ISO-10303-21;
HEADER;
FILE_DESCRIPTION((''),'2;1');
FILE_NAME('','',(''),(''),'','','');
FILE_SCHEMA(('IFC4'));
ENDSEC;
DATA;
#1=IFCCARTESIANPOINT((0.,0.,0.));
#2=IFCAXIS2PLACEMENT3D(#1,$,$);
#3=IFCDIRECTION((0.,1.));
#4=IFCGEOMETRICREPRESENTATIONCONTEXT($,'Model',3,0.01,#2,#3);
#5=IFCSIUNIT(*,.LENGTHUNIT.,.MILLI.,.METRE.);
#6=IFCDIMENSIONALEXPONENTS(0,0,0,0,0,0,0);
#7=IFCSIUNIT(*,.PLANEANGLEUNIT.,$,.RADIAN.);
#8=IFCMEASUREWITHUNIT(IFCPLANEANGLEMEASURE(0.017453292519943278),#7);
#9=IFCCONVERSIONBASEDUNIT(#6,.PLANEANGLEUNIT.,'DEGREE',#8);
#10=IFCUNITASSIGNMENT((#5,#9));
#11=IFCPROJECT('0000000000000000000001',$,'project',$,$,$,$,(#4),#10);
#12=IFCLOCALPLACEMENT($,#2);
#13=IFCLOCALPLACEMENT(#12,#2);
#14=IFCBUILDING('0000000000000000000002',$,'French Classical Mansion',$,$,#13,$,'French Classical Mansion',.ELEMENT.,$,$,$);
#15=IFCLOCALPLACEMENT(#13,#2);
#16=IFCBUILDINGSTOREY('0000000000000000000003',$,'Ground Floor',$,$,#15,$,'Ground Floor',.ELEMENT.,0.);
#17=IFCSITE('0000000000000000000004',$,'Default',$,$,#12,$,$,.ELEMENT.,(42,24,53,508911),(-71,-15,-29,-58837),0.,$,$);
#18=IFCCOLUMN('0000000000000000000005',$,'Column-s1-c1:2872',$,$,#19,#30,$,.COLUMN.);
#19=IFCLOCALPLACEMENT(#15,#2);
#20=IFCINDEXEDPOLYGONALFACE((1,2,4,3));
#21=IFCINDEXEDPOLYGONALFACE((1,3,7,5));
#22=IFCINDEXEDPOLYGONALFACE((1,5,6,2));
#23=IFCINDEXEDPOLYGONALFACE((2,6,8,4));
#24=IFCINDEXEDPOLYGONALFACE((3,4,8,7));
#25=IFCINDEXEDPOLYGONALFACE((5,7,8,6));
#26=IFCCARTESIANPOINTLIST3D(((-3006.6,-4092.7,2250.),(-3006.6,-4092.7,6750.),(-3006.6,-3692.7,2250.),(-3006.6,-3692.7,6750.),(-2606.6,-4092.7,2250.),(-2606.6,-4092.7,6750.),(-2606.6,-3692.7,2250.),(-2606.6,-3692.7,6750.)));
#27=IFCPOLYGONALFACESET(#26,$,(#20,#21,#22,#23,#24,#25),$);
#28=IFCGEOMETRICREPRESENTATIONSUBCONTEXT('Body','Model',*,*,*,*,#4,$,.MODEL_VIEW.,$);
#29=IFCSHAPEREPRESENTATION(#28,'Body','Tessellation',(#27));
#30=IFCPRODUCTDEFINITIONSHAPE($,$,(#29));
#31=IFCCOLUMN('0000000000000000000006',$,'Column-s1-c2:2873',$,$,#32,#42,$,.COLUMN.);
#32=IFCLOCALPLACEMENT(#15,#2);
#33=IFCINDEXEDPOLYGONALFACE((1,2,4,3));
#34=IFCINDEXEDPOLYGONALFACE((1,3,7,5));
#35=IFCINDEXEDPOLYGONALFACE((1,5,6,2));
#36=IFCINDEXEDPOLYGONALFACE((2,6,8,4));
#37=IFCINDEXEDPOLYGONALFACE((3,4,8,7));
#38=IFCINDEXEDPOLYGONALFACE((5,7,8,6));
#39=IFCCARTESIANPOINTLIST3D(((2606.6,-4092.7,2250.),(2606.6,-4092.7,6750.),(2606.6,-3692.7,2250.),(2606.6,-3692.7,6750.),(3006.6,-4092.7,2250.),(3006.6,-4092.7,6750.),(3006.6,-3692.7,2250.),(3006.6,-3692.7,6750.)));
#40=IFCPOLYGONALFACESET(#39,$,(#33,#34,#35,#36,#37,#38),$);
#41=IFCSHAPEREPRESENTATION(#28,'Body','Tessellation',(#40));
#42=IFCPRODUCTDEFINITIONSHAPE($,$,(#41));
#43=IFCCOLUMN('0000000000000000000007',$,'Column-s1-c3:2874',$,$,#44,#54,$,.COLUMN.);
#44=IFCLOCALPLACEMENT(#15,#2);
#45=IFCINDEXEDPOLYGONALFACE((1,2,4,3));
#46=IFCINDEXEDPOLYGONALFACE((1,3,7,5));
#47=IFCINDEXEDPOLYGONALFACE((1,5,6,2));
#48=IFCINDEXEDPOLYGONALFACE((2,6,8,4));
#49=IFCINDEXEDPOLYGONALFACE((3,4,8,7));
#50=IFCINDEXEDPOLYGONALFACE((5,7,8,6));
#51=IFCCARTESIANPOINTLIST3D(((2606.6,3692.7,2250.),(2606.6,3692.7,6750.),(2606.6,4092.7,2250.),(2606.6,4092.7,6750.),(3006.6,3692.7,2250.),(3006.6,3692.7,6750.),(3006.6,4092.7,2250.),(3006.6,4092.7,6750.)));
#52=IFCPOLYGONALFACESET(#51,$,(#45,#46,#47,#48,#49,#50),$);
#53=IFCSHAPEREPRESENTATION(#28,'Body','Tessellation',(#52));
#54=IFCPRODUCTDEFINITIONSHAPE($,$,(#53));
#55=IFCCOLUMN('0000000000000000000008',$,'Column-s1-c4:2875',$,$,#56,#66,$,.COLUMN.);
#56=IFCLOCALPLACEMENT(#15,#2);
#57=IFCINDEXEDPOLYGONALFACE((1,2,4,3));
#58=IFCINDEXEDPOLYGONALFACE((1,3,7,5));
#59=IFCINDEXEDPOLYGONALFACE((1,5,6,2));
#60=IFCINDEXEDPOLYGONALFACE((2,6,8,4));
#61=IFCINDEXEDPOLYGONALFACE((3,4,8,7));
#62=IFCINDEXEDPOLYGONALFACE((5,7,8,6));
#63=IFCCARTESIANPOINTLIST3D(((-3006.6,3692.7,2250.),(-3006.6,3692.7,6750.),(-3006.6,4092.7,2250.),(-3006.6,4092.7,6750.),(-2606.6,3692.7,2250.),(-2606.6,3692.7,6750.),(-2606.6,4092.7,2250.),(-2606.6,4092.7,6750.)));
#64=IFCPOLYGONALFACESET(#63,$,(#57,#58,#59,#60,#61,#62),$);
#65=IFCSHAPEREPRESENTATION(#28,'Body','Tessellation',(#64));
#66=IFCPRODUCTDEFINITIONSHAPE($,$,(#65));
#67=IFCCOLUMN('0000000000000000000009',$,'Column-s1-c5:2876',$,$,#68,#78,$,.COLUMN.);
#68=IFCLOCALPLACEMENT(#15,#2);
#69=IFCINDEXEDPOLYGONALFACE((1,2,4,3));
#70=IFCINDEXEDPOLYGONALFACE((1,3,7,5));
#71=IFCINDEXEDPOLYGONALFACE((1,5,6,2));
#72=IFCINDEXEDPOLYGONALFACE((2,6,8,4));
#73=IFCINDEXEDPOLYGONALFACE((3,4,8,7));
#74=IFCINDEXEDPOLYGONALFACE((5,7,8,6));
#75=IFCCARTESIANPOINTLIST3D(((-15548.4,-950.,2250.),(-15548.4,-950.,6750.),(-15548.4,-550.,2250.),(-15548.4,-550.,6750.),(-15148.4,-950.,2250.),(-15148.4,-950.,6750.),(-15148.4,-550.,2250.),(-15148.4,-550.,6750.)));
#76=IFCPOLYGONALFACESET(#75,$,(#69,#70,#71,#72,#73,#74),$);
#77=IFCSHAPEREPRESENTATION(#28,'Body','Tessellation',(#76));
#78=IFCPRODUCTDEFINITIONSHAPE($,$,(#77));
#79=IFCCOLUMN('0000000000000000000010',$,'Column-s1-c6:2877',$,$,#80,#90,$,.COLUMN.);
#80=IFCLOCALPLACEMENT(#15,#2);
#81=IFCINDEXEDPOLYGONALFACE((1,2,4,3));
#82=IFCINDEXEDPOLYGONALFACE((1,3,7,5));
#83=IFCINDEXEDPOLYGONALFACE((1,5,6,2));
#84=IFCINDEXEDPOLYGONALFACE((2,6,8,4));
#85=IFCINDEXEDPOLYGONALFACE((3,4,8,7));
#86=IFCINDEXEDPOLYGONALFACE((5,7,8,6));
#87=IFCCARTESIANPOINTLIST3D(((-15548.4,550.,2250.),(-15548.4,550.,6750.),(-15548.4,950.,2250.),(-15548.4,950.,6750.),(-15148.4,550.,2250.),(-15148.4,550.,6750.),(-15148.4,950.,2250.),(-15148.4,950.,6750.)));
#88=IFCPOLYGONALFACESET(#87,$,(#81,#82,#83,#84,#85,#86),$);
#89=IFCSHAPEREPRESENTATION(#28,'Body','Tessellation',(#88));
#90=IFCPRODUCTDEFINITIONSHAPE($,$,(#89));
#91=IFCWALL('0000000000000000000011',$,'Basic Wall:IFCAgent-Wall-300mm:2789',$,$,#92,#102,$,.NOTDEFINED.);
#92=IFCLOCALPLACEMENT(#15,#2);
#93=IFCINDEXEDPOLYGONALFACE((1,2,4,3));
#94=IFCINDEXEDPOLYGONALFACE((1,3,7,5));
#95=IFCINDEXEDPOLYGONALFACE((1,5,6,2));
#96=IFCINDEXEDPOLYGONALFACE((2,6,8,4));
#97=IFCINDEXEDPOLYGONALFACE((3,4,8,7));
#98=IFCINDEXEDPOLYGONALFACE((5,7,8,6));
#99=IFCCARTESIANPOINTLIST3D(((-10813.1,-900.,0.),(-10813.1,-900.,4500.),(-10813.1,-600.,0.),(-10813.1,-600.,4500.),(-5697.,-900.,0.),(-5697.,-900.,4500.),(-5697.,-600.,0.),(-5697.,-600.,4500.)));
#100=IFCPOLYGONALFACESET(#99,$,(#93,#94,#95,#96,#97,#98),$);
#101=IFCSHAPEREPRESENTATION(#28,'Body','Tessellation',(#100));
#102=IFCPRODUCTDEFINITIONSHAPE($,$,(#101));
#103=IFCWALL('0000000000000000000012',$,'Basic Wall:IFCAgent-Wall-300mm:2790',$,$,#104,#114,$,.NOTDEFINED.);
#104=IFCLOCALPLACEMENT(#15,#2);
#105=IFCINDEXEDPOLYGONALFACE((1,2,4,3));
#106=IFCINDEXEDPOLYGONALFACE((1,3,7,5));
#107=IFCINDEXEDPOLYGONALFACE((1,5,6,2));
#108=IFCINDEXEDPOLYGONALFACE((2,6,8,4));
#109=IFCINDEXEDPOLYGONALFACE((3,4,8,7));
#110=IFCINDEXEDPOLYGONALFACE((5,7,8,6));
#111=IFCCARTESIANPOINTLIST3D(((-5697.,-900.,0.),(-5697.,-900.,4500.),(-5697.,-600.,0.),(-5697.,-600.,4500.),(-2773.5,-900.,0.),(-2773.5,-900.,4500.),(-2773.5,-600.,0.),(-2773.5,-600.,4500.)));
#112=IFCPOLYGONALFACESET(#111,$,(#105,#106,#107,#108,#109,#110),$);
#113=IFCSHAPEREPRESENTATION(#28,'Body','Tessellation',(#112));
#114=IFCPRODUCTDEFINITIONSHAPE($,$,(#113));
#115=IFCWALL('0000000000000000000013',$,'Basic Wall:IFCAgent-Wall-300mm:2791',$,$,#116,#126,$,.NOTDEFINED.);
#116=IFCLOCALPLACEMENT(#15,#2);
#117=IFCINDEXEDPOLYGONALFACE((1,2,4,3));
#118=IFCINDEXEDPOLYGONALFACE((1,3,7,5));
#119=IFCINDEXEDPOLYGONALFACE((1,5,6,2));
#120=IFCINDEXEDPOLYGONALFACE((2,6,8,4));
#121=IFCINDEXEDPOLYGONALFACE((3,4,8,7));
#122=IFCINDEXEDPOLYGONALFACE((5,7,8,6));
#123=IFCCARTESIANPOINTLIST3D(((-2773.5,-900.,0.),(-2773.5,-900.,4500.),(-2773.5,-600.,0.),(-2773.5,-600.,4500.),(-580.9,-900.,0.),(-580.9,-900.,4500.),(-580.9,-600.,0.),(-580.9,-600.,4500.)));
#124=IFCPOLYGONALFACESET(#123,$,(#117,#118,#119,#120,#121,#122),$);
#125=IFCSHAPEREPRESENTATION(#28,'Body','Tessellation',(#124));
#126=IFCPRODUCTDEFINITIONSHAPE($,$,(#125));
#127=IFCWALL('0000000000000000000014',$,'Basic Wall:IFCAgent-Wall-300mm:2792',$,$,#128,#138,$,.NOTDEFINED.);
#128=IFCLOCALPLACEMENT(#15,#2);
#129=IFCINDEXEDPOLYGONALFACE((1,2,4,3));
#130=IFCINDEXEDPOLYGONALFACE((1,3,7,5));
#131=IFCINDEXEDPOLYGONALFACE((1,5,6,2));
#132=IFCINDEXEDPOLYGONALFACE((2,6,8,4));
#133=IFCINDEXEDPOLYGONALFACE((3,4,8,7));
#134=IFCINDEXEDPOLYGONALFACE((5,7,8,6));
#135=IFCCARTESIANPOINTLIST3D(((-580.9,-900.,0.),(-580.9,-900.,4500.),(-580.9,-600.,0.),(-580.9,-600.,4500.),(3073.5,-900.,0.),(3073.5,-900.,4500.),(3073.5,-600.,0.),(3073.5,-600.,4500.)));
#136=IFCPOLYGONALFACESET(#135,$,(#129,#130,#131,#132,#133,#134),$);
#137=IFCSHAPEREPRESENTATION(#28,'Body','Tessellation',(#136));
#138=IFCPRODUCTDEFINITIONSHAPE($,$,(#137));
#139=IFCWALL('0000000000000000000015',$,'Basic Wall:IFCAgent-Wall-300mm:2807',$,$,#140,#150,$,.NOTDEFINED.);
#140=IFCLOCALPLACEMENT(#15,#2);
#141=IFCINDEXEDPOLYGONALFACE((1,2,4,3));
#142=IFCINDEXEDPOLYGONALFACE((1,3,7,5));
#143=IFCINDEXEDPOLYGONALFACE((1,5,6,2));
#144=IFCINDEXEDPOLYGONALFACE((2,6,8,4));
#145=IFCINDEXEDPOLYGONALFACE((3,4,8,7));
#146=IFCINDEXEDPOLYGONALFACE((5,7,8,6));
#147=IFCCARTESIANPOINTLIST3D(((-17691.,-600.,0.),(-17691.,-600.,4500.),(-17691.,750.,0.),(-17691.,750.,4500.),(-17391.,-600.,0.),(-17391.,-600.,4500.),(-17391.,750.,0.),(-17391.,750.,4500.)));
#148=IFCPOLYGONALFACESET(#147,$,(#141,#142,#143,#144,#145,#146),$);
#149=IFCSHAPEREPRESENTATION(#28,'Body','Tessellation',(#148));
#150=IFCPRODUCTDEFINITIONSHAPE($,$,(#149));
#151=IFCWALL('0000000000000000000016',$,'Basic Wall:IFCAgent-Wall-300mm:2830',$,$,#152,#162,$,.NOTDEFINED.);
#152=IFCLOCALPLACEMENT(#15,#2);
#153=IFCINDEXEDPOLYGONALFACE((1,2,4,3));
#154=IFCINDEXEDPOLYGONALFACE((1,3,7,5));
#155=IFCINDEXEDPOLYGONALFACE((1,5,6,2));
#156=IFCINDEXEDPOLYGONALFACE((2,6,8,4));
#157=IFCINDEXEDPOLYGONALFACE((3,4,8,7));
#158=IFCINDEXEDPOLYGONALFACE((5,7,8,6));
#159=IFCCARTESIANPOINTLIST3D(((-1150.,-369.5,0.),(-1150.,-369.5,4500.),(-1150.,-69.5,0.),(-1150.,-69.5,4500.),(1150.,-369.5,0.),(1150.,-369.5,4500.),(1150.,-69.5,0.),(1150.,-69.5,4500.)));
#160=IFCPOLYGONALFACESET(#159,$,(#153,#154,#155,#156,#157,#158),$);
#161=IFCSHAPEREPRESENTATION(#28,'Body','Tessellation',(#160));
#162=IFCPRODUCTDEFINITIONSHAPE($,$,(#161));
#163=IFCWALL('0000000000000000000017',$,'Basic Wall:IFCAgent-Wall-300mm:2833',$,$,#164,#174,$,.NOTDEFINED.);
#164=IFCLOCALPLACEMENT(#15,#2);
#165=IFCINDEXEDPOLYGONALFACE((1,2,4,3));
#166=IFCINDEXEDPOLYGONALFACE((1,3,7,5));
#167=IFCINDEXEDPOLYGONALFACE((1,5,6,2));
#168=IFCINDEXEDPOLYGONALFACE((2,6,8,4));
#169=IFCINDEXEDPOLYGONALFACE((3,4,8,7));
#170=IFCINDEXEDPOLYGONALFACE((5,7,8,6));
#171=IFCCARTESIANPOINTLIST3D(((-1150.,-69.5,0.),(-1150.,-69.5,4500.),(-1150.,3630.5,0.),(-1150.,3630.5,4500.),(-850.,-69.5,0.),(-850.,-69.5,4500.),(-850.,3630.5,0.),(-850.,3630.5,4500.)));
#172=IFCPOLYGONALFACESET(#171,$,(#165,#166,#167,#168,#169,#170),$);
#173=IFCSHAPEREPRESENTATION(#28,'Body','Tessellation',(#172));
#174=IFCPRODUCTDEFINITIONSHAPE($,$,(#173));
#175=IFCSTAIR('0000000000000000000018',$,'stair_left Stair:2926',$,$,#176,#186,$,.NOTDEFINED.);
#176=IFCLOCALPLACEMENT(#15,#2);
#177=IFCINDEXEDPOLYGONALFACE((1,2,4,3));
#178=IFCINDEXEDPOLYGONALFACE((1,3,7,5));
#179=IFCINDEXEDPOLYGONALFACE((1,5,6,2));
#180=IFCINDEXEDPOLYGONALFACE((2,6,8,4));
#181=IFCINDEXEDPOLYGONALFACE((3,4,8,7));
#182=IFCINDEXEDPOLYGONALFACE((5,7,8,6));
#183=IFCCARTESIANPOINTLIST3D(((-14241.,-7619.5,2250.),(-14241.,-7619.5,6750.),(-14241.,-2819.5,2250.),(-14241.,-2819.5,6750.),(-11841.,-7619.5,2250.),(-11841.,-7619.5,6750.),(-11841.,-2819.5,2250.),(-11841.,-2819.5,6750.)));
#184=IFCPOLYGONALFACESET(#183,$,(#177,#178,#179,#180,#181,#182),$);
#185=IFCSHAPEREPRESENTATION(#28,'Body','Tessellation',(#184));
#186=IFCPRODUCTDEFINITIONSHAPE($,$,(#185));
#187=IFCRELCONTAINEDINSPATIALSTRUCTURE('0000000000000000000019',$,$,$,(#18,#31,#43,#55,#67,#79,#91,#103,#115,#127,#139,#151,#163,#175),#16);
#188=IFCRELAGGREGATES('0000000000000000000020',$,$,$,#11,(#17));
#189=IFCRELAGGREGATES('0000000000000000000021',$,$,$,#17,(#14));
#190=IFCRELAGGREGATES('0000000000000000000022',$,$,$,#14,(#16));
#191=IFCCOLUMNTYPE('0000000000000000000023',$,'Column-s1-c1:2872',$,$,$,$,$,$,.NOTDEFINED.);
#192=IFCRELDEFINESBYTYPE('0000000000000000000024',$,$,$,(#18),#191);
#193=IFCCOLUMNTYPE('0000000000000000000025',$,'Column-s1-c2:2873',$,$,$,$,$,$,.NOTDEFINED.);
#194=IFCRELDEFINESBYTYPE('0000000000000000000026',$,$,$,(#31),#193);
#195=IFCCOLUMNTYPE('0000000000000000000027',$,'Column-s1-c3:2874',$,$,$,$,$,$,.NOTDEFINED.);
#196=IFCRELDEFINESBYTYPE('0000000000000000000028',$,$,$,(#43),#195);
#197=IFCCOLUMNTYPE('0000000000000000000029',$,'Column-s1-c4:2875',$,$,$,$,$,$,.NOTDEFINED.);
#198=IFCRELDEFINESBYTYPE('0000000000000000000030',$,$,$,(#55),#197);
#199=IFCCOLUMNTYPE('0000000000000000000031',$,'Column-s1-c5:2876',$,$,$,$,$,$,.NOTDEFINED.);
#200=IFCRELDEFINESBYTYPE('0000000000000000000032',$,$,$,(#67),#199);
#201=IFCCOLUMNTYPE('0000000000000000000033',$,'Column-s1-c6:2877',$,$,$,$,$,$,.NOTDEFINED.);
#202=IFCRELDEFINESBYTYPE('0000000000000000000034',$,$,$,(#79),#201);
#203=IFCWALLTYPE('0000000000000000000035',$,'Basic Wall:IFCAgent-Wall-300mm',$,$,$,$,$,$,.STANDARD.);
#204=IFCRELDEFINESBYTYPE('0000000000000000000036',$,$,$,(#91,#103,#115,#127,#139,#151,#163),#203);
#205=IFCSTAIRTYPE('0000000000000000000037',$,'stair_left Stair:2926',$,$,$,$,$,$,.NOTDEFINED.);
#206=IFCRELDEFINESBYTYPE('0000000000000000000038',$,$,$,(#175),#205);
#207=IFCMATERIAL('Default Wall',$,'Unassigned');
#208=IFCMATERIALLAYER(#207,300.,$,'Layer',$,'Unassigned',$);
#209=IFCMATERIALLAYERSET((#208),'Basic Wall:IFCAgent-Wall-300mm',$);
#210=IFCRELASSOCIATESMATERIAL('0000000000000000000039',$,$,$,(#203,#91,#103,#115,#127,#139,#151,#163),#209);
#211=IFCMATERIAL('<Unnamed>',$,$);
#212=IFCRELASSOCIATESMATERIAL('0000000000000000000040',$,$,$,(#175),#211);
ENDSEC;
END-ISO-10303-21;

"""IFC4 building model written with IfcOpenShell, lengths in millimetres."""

from ifc_helpers import new_model, entity, si_unit, converted_unit, direction, frame, frame_2d, origin, origin_2d_with_axis, place, context, subcontext, project, spatial, rectangle, extrude, material, layer, layer_set, layer_usage, type_object, element, save


model = new_model("IFC4")

# Units and contexts
model_context = context("Model", 3, precision=0.01, world=origin(), true_north=direction((0.0, 1.0)))
body_context = subcontext(model_context, "Body", "Model", "MODEL_VIEW")
ifc_project = project(units=[si_unit("LENGTHUNIT", "METRE", prefix="MILLI"), converted_unit("PLANEANGLEUNIT", "DEGREE", entity("IfcPlaneAngleMeasure", 0.017453292519943278), si_unit("PLANEANGLEUNIT", "RADIAN"), dimensions=[0, 0, 0, 0, 0, 0, 0])], contexts=[model_context])

# Site, building, storey
site_placement = place(None, origin())
site = spatial("IfcSite", under=ifc_project, at=site_placement, Name="Default", CompositionType="ELEMENT", RefLatitude=(42, 24, 53, 508911), RefLongitude=(-71, -15, -29, -58837), RefElevation=0.0)
building_placement = place(site_placement, origin())
building = spatial("IfcBuilding", under=site, at=building_placement, Name="French Classical Mansion", LongName="French Classical Mansion", CompositionType="ELEMENT")
storey_placement = place(building_placement, origin())
storey = spatial("IfcBuildingStorey", under=building, at=storey_placement, Name="Ground Floor", LongName="Ground Floor", CompositionType="ELEMENT", Elevation=0.0)

# Columns
column_type_1 = type_object("IfcColumnType", Name="Column-s1-c1:2872", PredefinedType="NOTDEFINED")
column_1_placement = place(storey_placement, origin())
element("IfcColumn", 1, at=column_1_placement, inside=storey, type_object=column_type_1, Name="Column-s1-c1:2872", PredefinedType="COLUMN", context=body_context, shape_type="SweptSolid", body=[
    extrude(rectangle(XDim=400.0, YDim=400.0, at=origin_2d_with_axis()), frame((-2806.6, -3892.7, 2250.0)), (0.0, 0.0, 1.0), 4500.0),
])
column_type_2 = type_object("IfcColumnType", Name="Column-s1-c2:2873", PredefinedType="NOTDEFINED")
column_2_placement = place(storey_placement, origin())
element("IfcColumn", 2, at=column_2_placement, inside=storey, type_object=column_type_2, Name="Column-s1-c2:2873", PredefinedType="COLUMN", context=body_context, shape_type="SweptSolid", body=[
    extrude(rectangle(XDim=400.0, YDim=400.0, at=origin_2d_with_axis()), frame((2806.6, -3892.7, 2250.0)), (0.0, 0.0, 1.0), 4500.0),
])
column_type_3 = type_object("IfcColumnType", Name="Column-s1-c3:2874", PredefinedType="NOTDEFINED")
column_3_placement = place(storey_placement, origin())
element("IfcColumn", 3, at=column_3_placement, inside=storey, type_object=column_type_3, Name="Column-s1-c3:2874", PredefinedType="COLUMN", context=body_context, shape_type="SweptSolid", body=[
    extrude(rectangle(XDim=400.0, YDim=400.0, at=origin_2d_with_axis()), frame((2806.6, 3892.7, 2250.0)), (0.0, 0.0, 1.0), 4500.0),
])
column_type_4 = type_object("IfcColumnType", Name="Column-s1-c4:2875", PredefinedType="NOTDEFINED")
column_4_placement = place(storey_placement, origin())
element("IfcColumn", 4, at=column_4_placement, inside=storey, type_object=column_type_4, Name="Column-s1-c4:2875", PredefinedType="COLUMN", context=body_context, shape_type="SweptSolid", body=[
    extrude(rectangle(XDim=400.0, YDim=400.0, at=origin_2d_with_axis()), frame((-2806.6, 3892.7, 2250.0)), (0.0, 0.0, 1.0), 4500.0),
])
column_type_5 = type_object("IfcColumnType", Name="Column-s1-c5:2876", PredefinedType="NOTDEFINED")
column_5_placement = place(storey_placement, origin())
element("IfcColumn", 5, at=column_5_placement, inside=storey, type_object=column_type_5, Name="Column-s1-c5:2876", PredefinedType="COLUMN", context=body_context, shape_type="SweptSolid", body=[
    extrude(rectangle(XDim=400.0, YDim=400.0, at=origin_2d_with_axis()), frame((-15348.4, -750.0, 2250.0)), (0.0, 0.0, 1.0), 4500.0),
])
column_type_6 = type_object("IfcColumnType", Name="Column-s1-c6:2877", PredefinedType="NOTDEFINED")
column_6_placement = place(storey_placement, origin())
element("IfcColumn", 6, at=column_6_placement, inside=storey, type_object=column_type_6, Name="Column-s1-c6:2877", PredefinedType="COLUMN", context=body_context, shape_type="SweptSolid", body=[
    extrude(rectangle(XDim=400.0, YDim=400.0, at=origin_2d_with_axis()), frame((-15348.4, 750.0, 2250.0)), (0.0, 0.0, 1.0), 4500.0),
])

# Shared definitions
ifc_material_1 = material(Name="<Unnamed>")

# Walls
ifc_material_2 = material(Name="Default Wall", Category="Unassigned")
ifc_layer_1 = layer(ifc_material_2, 300.0, Name="Layer", Category="Unassigned")
ifc_layer_set_1 = layer_set([ifc_layer_1], Name="Basic Wall:IFCAgent-Wall-300mm")
ifc_layer_usage_1 = layer_usage(ifc_layer_set_1, "AXIS2", "NEGATIVE", 150.0)
wall_type = type_object("IfcWallType", Name="Basic Wall:IFCAgent-Wall-300mm", PredefinedType="STANDARD", material=ifc_layer_set_1)
wall_1_placement = place(storey_placement, frame((-10813.1, -750.0, 0.0)))
element("IfcWall", 7, at=wall_1_placement, inside=storey, type_object=wall_type, material=ifc_layer_usage_1, Name="Basic Wall:IFCAgent-Wall-300mm:2789", PredefinedType="NOTDEFINED", context=body_context, shape_type="SweptSolid", body=[
    extrude(rectangle(XDim=5116.1, YDim=300.0, at=frame_2d((2558.1, 0.0), x_axis=(-1.0, 0.0))), origin(), (0.0, 0.0, 1.0), 4500.0),
])
ifc_layer_usage_2 = layer_usage(ifc_layer_set_1, "AXIS2", "NEGATIVE", 150.0)
wall_2_placement = place(storey_placement, frame((-5697.0, -750.0, 0.0)))
element("IfcWall", 8, at=wall_2_placement, inside=storey, type_object=wall_type, material=ifc_layer_usage_2, Name="Basic Wall:IFCAgent-Wall-300mm:2790", PredefinedType="NOTDEFINED", context=body_context, shape_type="SweptSolid", body=[
    extrude(rectangle(XDim=2923.5, YDim=300.0, at=frame_2d((1461.7, 0.0), x_axis=(-1.0, 0.0))), origin(), (0.0, 0.0, 1.0), 4500.0),
])
ifc_layer_usage_3 = layer_usage(ifc_layer_set_1, "AXIS2", "NEGATIVE", 150.0)
wall_3_placement = place(storey_placement, frame((-2773.5, -750.0, 0.0)))
element("IfcWall", 9, at=wall_3_placement, inside=storey, type_object=wall_type, material=ifc_layer_usage_3, Name="Basic Wall:IFCAgent-Wall-300mm:2791", PredefinedType="NOTDEFINED", context=body_context, shape_type="SweptSolid", body=[
    extrude(rectangle(XDim=2192.6, YDim=300.0, at=frame_2d((1096.3, 0.0), x_axis=(-1.0, 0.0))), origin(), (0.0, 0.0, 1.0), 4500.0),
])
ifc_layer_usage_4 = layer_usage(ifc_layer_set_1, "AXIS2", "NEGATIVE", 150.0)
wall_4_placement = place(storey_placement, frame((-580.9, -750.0, 0.0)))
element("IfcWall", 10, at=wall_4_placement, inside=storey, type_object=wall_type, material=ifc_layer_usage_4, Name="Basic Wall:IFCAgent-Wall-300mm:2792", PredefinedType="NOTDEFINED", context=body_context, shape_type="SweptSolid", body=[
    extrude(rectangle(XDim=3654.4, YDim=300.0, at=frame_2d((1827.2, 0.0), x_axis=(-1.0, 0.0))), origin(), (0.0, 0.0, 1.0), 4500.0),
])
ifc_layer_usage_5 = layer_usage(ifc_layer_set_1, "AXIS2", "NEGATIVE", 150.0)
wall_5_placement = place(storey_placement, frame((-17541.0, -600.0, 0.0), z_axis=(0.0, 0.0, 1.0), x_axis=(0.0, 1.0, 0.0)))
element("IfcWall", 11, at=wall_5_placement, inside=storey, type_object=wall_type, material=ifc_layer_usage_5, Name="Basic Wall:IFCAgent-Wall-300mm:2807", PredefinedType="NOTDEFINED", context=body_context, shape_type="SweptSolid", body=[
    extrude(rectangle(XDim=1350.0, YDim=300.0, at=frame_2d((675.0, 0.0), x_axis=(-1.0, 0.0))), origin(), (0.0, 0.0, 1.0), 4500.0),
])
ifc_layer_usage_6 = layer_usage(ifc_layer_set_1, "AXIS2", "NEGATIVE", 150.0)
wall_6_placement = place(storey_placement, frame((-1150.0, -219.5, 0.0)))
element("IfcWall", 12, at=wall_6_placement, inside=storey, type_object=wall_type, material=ifc_layer_usage_6, Name="Basic Wall:IFCAgent-Wall-300mm:2830", PredefinedType="NOTDEFINED", context=body_context, shape_type="SweptSolid", body=[
    extrude(rectangle(XDim=2300.0, YDim=300.0, at=frame_2d((1150.0, 0.0), x_axis=(-1.0, 0.0))), origin(), (0.0, 0.0, 1.0), 4500.0),
])
ifc_layer_usage_7 = layer_usage(ifc_layer_set_1, "AXIS2", "NEGATIVE", 150.0)
wall_7_placement = place(storey_placement, frame((-1000.0, 3630.5, 0.0), z_axis=(0.0, 0.0, 1.0), x_axis=(0.0, -1.0, 0.0)))
element("IfcWall", 13, at=wall_7_placement, inside=storey, type_object=wall_type, material=ifc_layer_usage_7, Name="Basic Wall:IFCAgent-Wall-300mm:2833", PredefinedType="NOTDEFINED", context=body_context, shape_type="SweptSolid", body=[
    extrude(rectangle(XDim=3700.0, YDim=300.0, at=frame_2d((1850.0, 0.0), x_axis=(-1.0, 0.0))), origin(), (0.0, 0.0, 1.0), 4500.0),
])

# Stair
stair_type_1 = type_object("IfcStairType", Name="stair_left Stair:2926", PredefinedType="NOTDEFINED")
stair_1_placement = place(storey_placement, origin())
element("IfcStair", 14, at=stair_1_placement, inside=storey, type_object=stair_type_1, material=ifc_material_1, Name="stair_left Stair:2926", PredefinedType="NOTDEFINED", context=body_context, shape_type="SweptSolid", body=[
    extrude(rectangle(XDim=2400.0, YDim=4800.0, at=origin_2d_with_axis()), frame((-13041.0, -5219.5, 2250.0)), (0.0, 0.0, 1.0), 4500.0),
])

save(model, "model.ifc")
